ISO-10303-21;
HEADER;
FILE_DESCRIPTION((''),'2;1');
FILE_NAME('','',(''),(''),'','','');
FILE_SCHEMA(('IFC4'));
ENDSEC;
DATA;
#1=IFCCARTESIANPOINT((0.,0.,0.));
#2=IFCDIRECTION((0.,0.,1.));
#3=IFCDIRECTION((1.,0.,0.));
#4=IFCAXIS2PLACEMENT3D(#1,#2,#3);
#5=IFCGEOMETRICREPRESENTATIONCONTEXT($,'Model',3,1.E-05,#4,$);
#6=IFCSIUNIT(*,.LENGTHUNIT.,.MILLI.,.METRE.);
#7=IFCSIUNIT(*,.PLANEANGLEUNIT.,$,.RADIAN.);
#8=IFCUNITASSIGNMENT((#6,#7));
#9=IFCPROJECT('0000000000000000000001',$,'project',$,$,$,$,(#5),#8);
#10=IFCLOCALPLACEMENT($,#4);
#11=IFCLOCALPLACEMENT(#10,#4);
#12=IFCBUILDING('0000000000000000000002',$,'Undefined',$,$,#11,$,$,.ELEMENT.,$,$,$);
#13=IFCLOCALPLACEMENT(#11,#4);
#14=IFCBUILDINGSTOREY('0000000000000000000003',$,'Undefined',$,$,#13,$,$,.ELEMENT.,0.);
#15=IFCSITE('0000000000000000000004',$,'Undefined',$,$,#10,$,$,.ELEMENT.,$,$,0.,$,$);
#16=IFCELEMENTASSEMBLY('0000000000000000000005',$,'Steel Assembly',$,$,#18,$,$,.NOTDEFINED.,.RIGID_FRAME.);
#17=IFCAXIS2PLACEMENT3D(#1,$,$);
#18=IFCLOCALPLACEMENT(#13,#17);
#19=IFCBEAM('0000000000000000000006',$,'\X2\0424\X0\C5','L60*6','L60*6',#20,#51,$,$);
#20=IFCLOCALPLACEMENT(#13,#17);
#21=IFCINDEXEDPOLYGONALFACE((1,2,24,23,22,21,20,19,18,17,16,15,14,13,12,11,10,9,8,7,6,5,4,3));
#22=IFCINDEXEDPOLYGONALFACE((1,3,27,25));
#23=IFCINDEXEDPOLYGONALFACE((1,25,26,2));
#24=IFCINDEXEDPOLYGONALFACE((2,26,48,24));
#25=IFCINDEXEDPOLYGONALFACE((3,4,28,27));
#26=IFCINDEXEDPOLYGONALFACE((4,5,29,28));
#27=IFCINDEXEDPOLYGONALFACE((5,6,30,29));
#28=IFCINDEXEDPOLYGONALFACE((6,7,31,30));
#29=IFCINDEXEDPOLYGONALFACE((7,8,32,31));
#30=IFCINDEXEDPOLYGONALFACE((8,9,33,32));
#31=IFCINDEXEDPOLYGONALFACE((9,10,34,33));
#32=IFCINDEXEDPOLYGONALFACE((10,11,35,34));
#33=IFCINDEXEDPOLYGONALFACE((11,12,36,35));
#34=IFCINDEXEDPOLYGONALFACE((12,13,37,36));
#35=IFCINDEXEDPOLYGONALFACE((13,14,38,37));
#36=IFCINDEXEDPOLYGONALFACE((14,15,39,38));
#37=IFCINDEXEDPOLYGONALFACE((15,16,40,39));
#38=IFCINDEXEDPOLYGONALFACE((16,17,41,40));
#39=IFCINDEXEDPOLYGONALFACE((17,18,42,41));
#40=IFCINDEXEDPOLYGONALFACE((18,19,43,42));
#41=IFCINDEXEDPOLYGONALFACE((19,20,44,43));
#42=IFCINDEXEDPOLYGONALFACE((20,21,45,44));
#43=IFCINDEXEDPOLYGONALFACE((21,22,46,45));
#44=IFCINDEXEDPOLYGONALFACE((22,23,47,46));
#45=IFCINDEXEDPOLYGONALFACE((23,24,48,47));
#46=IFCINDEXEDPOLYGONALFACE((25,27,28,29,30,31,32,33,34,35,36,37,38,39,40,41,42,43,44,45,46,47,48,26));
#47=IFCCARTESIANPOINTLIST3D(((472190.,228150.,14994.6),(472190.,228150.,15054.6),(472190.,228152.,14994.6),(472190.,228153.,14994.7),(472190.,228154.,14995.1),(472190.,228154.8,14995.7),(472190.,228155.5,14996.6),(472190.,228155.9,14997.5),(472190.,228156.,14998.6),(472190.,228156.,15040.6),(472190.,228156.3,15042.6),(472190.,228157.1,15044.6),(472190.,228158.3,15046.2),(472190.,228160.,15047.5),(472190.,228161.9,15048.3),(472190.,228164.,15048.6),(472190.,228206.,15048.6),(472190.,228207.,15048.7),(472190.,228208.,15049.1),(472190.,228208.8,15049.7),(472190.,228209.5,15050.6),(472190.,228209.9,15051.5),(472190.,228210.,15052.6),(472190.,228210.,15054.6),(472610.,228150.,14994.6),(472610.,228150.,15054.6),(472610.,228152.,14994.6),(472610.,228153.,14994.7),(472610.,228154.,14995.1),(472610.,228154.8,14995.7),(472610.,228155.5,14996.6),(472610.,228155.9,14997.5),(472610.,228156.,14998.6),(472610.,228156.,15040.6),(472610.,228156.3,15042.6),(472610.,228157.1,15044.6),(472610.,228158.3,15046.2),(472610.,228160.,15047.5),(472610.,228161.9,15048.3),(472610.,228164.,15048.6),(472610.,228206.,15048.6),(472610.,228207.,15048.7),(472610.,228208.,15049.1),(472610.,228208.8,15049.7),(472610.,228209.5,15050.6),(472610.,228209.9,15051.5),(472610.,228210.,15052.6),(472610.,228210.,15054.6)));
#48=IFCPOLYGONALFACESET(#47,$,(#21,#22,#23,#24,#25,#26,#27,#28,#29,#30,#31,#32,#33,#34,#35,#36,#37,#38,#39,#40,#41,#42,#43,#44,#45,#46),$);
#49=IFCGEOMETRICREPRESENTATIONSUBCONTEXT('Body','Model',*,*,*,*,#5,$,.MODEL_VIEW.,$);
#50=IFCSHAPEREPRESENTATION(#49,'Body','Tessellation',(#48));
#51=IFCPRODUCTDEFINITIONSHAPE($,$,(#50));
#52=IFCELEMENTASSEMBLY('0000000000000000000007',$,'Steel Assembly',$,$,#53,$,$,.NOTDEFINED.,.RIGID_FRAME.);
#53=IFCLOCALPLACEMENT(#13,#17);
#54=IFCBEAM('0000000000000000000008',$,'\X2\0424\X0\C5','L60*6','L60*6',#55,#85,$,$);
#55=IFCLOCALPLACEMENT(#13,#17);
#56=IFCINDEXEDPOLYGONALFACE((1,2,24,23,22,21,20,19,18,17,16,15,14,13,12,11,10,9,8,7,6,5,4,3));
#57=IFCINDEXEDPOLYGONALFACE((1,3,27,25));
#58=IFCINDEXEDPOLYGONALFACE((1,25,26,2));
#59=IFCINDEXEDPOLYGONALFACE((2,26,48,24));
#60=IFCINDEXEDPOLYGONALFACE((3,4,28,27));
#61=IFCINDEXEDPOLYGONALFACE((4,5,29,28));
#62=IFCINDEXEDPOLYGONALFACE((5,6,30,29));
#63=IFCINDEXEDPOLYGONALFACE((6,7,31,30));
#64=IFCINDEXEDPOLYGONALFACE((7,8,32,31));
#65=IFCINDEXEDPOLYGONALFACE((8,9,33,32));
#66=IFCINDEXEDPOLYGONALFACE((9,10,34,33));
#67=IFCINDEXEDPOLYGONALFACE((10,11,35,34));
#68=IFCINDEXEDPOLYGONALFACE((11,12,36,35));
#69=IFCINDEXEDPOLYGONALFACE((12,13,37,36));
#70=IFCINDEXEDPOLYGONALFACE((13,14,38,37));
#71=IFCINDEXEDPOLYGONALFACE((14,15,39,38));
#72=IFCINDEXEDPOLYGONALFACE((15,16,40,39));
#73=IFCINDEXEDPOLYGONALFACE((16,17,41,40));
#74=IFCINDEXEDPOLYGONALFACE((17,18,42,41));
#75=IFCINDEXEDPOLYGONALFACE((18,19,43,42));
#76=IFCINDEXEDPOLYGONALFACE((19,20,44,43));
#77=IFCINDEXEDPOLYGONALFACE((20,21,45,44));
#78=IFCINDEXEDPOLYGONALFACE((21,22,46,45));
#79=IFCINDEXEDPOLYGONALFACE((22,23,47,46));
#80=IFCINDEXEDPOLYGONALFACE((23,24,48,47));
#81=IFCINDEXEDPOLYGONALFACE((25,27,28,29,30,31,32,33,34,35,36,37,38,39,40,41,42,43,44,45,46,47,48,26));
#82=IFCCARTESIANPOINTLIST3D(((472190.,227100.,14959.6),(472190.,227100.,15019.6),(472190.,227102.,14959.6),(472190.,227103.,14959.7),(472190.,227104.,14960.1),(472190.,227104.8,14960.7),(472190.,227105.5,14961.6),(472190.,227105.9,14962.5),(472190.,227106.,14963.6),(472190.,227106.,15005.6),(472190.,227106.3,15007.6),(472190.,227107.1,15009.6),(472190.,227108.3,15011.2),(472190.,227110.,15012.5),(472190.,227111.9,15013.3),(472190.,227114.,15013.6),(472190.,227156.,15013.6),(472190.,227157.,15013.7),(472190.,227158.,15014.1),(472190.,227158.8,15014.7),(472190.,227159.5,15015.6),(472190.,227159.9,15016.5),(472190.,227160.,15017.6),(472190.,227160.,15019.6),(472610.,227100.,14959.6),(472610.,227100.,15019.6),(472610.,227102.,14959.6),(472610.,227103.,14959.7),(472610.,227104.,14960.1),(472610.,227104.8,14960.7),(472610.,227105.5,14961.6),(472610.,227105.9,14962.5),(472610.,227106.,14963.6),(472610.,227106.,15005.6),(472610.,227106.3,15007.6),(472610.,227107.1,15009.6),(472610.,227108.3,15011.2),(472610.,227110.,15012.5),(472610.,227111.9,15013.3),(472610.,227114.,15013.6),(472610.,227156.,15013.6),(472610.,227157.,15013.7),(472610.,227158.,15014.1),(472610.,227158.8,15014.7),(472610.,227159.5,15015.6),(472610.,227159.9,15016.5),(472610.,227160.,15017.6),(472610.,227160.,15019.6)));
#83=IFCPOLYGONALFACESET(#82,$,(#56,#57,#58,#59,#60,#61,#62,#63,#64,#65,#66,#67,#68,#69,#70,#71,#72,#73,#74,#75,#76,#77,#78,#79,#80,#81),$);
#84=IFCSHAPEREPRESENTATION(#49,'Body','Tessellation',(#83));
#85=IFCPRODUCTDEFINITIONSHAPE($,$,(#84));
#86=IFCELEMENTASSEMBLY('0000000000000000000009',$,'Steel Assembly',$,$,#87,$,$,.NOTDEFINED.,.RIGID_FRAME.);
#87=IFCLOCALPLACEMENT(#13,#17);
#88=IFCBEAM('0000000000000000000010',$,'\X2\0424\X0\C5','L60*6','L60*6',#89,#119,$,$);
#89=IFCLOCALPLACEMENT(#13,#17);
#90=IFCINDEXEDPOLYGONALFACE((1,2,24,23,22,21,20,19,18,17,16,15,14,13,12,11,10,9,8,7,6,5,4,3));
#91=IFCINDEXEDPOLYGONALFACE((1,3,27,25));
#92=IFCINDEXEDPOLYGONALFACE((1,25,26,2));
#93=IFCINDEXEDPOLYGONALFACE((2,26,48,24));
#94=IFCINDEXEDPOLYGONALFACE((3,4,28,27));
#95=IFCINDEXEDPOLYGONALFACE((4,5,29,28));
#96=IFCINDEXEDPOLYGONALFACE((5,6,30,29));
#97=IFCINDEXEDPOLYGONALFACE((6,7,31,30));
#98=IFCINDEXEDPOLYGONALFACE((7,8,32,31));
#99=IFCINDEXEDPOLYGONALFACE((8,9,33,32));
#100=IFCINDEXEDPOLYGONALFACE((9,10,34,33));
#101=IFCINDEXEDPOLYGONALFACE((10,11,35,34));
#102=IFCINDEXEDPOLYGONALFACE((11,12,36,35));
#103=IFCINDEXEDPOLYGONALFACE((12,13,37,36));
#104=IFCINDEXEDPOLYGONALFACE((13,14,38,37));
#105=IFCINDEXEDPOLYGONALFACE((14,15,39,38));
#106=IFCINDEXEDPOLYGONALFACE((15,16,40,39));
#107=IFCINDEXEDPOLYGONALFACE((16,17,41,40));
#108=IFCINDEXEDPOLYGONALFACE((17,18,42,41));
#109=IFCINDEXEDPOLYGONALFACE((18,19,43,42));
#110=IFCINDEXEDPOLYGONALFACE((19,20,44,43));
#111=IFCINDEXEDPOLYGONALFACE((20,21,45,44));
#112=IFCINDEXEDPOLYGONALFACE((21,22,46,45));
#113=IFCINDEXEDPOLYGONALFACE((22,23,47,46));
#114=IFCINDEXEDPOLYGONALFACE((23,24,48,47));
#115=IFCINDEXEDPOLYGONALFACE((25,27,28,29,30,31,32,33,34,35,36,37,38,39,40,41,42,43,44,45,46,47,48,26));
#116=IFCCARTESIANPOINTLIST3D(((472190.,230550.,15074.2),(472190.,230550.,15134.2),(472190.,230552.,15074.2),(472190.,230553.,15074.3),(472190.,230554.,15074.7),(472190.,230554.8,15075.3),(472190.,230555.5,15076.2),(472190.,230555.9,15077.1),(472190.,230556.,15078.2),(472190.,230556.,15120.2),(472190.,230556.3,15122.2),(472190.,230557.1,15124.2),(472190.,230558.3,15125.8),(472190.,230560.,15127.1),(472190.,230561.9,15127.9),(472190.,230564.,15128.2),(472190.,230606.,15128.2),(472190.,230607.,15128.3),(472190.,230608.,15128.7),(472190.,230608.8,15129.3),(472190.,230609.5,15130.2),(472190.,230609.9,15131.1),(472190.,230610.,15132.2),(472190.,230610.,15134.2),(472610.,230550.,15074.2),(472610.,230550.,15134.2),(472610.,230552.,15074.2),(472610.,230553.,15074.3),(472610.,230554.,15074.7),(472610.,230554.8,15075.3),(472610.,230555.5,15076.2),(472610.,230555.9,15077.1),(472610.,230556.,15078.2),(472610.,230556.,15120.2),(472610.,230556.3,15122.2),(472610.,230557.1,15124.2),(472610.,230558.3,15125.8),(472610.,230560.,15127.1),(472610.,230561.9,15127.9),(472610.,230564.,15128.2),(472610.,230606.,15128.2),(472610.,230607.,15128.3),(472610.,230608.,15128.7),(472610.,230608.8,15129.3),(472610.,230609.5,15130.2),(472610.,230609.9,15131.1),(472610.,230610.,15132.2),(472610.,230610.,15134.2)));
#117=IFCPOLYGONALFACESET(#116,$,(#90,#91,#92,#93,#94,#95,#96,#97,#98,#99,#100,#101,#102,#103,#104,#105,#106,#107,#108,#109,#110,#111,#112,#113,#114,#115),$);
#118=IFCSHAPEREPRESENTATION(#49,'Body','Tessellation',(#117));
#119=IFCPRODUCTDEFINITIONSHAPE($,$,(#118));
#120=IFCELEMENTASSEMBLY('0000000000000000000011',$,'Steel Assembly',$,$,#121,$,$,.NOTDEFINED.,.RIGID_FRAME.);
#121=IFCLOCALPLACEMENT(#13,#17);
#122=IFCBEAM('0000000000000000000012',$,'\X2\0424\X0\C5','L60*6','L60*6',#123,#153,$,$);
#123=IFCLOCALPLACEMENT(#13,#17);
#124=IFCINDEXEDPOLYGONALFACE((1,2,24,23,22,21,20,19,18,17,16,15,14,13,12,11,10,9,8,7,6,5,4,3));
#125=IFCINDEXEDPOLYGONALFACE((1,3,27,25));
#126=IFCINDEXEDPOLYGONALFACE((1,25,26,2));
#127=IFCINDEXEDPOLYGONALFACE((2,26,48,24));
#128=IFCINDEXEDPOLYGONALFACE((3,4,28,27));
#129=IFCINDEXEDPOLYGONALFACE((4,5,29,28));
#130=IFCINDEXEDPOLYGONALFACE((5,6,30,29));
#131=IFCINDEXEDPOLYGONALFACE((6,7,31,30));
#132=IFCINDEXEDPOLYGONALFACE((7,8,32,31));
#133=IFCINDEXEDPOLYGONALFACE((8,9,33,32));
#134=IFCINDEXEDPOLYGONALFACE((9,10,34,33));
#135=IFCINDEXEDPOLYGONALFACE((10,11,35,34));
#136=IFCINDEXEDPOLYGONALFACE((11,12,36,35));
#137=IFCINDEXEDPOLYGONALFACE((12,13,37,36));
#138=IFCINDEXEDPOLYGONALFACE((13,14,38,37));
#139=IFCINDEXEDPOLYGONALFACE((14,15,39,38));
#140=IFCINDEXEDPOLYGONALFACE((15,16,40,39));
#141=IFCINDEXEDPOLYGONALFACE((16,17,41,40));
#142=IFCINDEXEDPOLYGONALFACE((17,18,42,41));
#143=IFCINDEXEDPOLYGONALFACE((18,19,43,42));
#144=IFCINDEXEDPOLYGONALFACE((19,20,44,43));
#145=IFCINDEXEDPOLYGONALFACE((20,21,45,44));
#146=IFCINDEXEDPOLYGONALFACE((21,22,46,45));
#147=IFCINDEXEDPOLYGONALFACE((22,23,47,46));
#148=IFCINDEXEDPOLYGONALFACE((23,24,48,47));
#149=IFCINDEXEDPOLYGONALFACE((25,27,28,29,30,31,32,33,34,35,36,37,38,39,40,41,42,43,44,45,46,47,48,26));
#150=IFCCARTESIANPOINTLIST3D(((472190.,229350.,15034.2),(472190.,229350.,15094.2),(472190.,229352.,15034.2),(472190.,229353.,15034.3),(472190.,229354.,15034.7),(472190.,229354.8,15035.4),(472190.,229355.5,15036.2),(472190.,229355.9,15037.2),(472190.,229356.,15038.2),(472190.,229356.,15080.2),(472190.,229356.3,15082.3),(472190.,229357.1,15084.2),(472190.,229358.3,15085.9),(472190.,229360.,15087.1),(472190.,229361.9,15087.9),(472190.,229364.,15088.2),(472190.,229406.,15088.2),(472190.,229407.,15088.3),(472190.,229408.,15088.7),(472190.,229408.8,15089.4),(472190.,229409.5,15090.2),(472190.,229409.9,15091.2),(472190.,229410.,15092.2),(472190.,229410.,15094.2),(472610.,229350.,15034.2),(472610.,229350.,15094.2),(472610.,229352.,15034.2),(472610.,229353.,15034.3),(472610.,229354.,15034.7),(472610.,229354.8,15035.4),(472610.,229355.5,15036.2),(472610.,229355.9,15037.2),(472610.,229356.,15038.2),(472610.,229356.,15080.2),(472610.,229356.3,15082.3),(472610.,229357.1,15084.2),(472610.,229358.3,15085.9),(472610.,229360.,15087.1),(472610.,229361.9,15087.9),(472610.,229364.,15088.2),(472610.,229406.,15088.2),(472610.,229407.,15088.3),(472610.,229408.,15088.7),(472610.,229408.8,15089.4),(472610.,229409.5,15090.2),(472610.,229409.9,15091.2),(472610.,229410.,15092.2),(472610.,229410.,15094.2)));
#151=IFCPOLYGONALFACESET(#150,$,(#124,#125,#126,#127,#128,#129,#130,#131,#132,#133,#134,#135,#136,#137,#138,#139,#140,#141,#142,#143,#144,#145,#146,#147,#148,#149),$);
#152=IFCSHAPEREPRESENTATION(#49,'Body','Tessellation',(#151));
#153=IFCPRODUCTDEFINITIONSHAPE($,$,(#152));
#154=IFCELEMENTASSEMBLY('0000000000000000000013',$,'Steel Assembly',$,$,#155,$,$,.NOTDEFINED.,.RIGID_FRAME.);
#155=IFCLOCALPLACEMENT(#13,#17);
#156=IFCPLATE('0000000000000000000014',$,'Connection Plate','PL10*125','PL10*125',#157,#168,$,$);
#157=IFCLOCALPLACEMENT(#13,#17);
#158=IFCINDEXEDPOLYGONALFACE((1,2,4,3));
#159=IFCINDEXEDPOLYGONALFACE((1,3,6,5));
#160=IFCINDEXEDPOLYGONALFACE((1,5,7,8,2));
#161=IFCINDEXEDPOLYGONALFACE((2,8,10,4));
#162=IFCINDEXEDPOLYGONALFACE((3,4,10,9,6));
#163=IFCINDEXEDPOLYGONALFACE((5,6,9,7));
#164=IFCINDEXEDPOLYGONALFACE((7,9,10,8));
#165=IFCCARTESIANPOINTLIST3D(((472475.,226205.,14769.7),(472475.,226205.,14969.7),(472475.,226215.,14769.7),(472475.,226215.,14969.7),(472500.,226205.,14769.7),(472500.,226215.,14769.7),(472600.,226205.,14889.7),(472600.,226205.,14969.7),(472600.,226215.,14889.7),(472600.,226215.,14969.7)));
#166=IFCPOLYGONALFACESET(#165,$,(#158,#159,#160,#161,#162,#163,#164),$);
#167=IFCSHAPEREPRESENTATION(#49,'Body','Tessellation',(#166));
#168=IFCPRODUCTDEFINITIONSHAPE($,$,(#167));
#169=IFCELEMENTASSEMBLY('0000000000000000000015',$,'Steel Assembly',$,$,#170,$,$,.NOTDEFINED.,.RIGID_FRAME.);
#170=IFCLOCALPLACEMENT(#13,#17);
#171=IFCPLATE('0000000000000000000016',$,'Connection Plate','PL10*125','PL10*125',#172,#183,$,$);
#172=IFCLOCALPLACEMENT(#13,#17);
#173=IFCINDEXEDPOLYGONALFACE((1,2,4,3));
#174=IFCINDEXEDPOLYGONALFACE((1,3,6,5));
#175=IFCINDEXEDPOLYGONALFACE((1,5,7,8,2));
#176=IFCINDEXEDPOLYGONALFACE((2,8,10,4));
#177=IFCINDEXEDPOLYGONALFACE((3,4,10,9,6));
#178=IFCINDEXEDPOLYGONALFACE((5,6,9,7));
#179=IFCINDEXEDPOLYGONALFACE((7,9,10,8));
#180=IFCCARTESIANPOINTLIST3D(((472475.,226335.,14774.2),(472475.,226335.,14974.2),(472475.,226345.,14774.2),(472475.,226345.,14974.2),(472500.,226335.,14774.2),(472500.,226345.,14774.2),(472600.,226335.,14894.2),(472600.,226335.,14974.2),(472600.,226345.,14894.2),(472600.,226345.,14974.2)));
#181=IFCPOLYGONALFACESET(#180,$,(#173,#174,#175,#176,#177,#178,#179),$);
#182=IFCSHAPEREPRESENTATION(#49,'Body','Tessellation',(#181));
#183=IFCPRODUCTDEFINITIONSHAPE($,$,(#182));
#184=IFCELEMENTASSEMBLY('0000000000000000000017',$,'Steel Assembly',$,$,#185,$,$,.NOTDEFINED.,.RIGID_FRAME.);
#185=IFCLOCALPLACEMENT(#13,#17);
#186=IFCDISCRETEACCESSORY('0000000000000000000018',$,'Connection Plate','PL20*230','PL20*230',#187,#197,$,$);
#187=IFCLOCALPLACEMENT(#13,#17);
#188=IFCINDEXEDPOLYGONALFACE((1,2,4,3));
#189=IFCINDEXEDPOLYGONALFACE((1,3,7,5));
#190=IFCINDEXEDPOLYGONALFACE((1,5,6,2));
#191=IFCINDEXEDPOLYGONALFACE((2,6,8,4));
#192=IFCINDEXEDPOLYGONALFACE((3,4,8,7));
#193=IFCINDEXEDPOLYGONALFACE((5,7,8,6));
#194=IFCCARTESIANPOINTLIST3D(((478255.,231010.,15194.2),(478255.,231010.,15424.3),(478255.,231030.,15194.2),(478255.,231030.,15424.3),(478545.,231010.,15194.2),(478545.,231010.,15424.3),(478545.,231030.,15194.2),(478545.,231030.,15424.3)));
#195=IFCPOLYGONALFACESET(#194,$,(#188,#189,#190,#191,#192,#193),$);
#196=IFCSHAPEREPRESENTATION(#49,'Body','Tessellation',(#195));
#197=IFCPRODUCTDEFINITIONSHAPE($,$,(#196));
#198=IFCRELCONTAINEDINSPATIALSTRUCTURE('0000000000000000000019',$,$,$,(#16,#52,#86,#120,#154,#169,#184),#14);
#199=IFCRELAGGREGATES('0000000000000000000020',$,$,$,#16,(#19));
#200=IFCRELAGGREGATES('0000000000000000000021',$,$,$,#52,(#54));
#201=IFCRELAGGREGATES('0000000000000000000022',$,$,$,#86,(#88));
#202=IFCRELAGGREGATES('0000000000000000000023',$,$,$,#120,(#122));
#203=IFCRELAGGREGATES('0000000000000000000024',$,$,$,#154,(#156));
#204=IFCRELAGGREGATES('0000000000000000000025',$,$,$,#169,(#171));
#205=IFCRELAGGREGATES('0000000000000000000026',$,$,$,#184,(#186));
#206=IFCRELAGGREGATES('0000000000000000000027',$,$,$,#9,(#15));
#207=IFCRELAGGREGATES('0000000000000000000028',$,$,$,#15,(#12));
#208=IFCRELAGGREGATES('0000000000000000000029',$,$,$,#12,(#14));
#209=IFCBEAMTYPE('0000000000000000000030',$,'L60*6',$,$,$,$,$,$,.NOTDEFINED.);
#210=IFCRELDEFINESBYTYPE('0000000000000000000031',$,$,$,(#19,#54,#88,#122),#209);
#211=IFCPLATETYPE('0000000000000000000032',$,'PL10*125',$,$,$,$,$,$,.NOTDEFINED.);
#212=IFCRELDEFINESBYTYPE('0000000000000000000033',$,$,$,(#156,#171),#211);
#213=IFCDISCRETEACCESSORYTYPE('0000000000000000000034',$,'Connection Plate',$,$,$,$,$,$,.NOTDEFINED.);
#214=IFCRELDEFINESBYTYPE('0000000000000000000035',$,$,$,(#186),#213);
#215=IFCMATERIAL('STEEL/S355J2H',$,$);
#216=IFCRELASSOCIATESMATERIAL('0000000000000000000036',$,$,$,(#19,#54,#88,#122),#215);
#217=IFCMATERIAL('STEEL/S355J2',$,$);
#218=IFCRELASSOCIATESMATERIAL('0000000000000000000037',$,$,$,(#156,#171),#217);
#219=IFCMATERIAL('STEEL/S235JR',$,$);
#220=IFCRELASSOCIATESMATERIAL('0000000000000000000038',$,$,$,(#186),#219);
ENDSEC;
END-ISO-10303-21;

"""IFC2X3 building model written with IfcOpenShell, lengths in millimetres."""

from ifc_helpers import new_model, si_unit, frame, origin_with_axes, origin_2d_with_axis, place, context, subcontext, project, spatial, polyline, l_section, outline, extrude, material, type_object, element, aggregate, save


model = new_model("IFC2X3")

# Units and contexts
model_context = context("Model", 3, precision=1e-05, world=origin_with_axes())
body_context = subcontext(model_context, "Body", "Model", "MODEL_VIEW")
ifc_project = project(units=[si_unit("LENGTHUNIT", "METRE", prefix="MILLI"), si_unit("PLANEANGLEUNIT", "RADIAN")], contexts=[model_context])

# Site, building, storey
site_placement = place(None, origin_with_axes())
site = spatial("IfcSite", under=ifc_project, at=site_placement, Name="Undefined", CompositionType="ELEMENT", RefElevation=0.0)
building_placement = place(site_placement, origin_with_axes())
building = spatial("IfcBuilding", under=site, at=building_placement, Name="Undefined", CompositionType="ELEMENT")
storey_placement = place(building_placement, origin_with_axes())
storey = spatial("IfcBuildingStorey", under=building, at=storey_placement, Name="Undefined", CompositionType="ELEMENT", Elevation=0.0)

# Element assemblies, beams
assembly_1_placement = place(storey_placement, origin_with_axes())
assembly_1 = element("IfcElementAssembly", 1, at=assembly_1_placement, inside=storey, Name="Steel Assembly", AssemblyPlace="NOTDEFINED", PredefinedType="RIGID_FRAME")
ifc_material_1 = material(Name="STEEL/S355J2H")
beam_type = type_object("IfcBeamType", Name="L60*6", PredefinedType="NOTDEFINED")
beam_1_placement = place(assembly_1_placement, frame((472610.0, 228180.0, 15024.6), z_axis=(0.0, 1.0, 0.0), x_axis=(-1.0, 0.0, 0.0)))
beam_1 = element("IfcBeam", 2, at=beam_1_placement, type_object=beam_type, material=ifc_material_1, Name="ФC5", Description="L60*6", ObjectType="L60*6", context=body_context, shape_type="SweptSolid", body=[
    extrude(l_section(Depth=60.0, Width=60.0, Thickness=6.0, FilletRadius=8.0, EdgeRadius=4.0, at=origin_2d_with_axis()), frame((420.0, 0.0, 0.0), z_axis=(-1.0, 0.0, 0.0), x_axis=(0.0, -1.0, 0.0)), (0.0, 0.0, 1.0), 420.0),
])
aggregate(assembly_1, [beam_1])
assembly_2_placement = place(storey_placement, origin_with_axes())
assembly_2 = element("IfcElementAssembly", 3, at=assembly_2_placement, inside=storey, Name="Steel Assembly", AssemblyPlace="NOTDEFINED", PredefinedType="RIGID_FRAME")
beam_2_placement = place(assembly_2_placement, frame((472610.0, 227130.0, 14989.6), z_axis=(0.0, 1.0, 0.0), x_axis=(-1.0, 0.0, 0.0)))
beam_2 = element("IfcBeam", 4, at=beam_2_placement, type_object=beam_type, material=ifc_material_1, Name="ФC5", Description="L60*6", ObjectType="L60*6", context=body_context, shape_type="SweptSolid", body=[
    extrude(l_section(Depth=60.0, Width=60.0, Thickness=6.0, FilletRadius=8.0, EdgeRadius=4.0, at=origin_2d_with_axis()), frame((420.0, 0.0, 0.0), z_axis=(-1.0, 0.0, 0.0), x_axis=(0.0, -1.0, 0.0)), (0.0, 0.0, 1.0), 420.0),
])
aggregate(assembly_2, [beam_2])
assembly_3_placement = place(storey_placement, origin_with_axes())
assembly_3 = element("IfcElementAssembly", 5, at=assembly_3_placement, inside=storey, Name="Steel Assembly", AssemblyPlace="NOTDEFINED", PredefinedType="RIGID_FRAME")
beam_3_placement = place(assembly_3_placement, frame((472610.0, 230580.0, 15104.2), z_axis=(0.0, 1.0, 0.0), x_axis=(-1.0, 0.0, 0.0)))
beam_3 = element("IfcBeam", 6, at=beam_3_placement, type_object=beam_type, material=ifc_material_1, Name="ФC5", Description="L60*6", ObjectType="L60*6", context=body_context, shape_type="SweptSolid", body=[
    extrude(l_section(Depth=60.0, Width=60.0, Thickness=6.0, FilletRadius=8.0, EdgeRadius=4.0, at=origin_2d_with_axis()), frame((420.0, 0.0, 0.0), z_axis=(-1.0, 0.0, 0.0), x_axis=(0.0, -1.0, 0.0)), (0.0, 0.0, 1.0), 420.0),
])
aggregate(assembly_3, [beam_3])
assembly_4_placement = place(storey_placement, origin_with_axes())
assembly_4 = element("IfcElementAssembly", 7, at=assembly_4_placement, inside=storey, Name="Steel Assembly", AssemblyPlace="NOTDEFINED", PredefinedType="RIGID_FRAME")
beam_4_placement = place(assembly_4_placement, frame((472610.0, 229380.0, 15064.2), z_axis=(0.0, 1.0, 0.0), x_axis=(-1.0, 0.0, 0.0)))
beam_4 = element("IfcBeam", 8, at=beam_4_placement, type_object=beam_type, material=ifc_material_1, Name="ФC5", Description="L60*6", ObjectType="L60*6", context=body_context, shape_type="SweptSolid", body=[
    extrude(l_section(Depth=60.0, Width=60.0, Thickness=6.0, FilletRadius=8.0, EdgeRadius=4.0, at=origin_2d_with_axis()), frame((420.0, 0.0, 0.0), z_axis=(-1.0, 0.0, 0.0), x_axis=(0.0, -1.0, 0.0)), (0.0, 0.0, 1.0), 420.0),
])
aggregate(assembly_4, [beam_4])

# Element assemblies, plates
assembly_5_placement = place(storey_placement, origin_with_axes())
assembly_5 = element("IfcElementAssembly", 9, at=assembly_5_placement, inside=storey, Name="Steel Assembly", AssemblyPlace="NOTDEFINED", PredefinedType="RIGID_FRAME")
ifc_material_2 = material(Name="STEEL/S355J2")
plate_type = type_object("IfcPlateType", Name="PL10*125", PredefinedType="NOTDEFINED")
plate_1_placement = place(assembly_5_placement, frame((472600.0, 226210.0, 14969.7), z_axis=(0.0, -1.0, 0.0), x_axis=(-1.0, 0.0, 0.0)))
plate_1 = element("IfcPlate", 10, at=plate_1_placement, type_object=plate_type, material=ifc_material_2, Name="Connection Plate", Description="PL10*125", ObjectType="PL10*125", context=body_context, shape_type="SweptSolid", body=[
    extrude(outline(polyline([(0.0, 0.0), (125.0, 0.0), (125.0, 200.0), (100.0, 200.0), (0.0, 80.0), (0.0, 0.0)])), frame((0.0, 0.0, -5.0), z_axis=(0.0, 0.0, 1.0), x_axis=(1.0, 0.0, 0.0)), (0.0, 0.0, 1.0), 10.0),
])
aggregate(assembly_5, [plate_1])
assembly_6_placement = place(storey_placement, origin_with_axes())
assembly_6 = element("IfcElementAssembly", 11, at=assembly_6_placement, inside=storey, Name="Steel Assembly", AssemblyPlace="NOTDEFINED", PredefinedType="RIGID_FRAME")
plate_2_placement = place(assembly_6_placement, frame((472600.0, 226340.0, 14974.2), z_axis=(0.0, -1.0, 0.0), x_axis=(-1.0, 0.0, 0.0)))
plate_2 = element("IfcPlate", 12, at=plate_2_placement, type_object=plate_type, material=ifc_material_2, Name="Connection Plate", Description="PL10*125", ObjectType="PL10*125", context=body_context, shape_type="SweptSolid", body=[
    extrude(outline(polyline([(0.0, 0.0), (125.0, 0.0), (125.0, 200.0), (100.0, 200.0), (0.0, 80.0), (0.0, 0.0)])), frame((0.0, 0.0, -5.0), z_axis=(0.0, 0.0, 1.0), x_axis=(1.0, 0.0, 0.0)), (0.0, 0.0, 1.0), 10.0),
])
aggregate(assembly_6, [plate_2])

# Element assembly, discrete accessory
assembly_7_placement = place(storey_placement, origin_with_axes())
assembly_7 = element("IfcElementAssembly", 13, at=assembly_7_placement, inside=storey, Name="Steel Assembly", AssemblyPlace="NOTDEFINED", PredefinedType="RIGID_FRAME")
ifc_material_3 = material(Name="STEEL/S235JR")
discrete_accessory_type_1 = type_object("IfcDiscreteAccessoryType", Name="Connection Plate")
discrete_accessory_1_placement = place(assembly_7_placement, frame((478545.0, 231020.0, 15424.3), z_axis=(0.0, -1.0, 0.0), x_axis=(-1.0, 0.0, 0.0)))
discrete_accessory_1 = element("IfcDiscreteAccessory", 14, at=discrete_accessory_1_placement, type_object=discrete_accessory_type_1, material=ifc_material_3, Name="Connection Plate", Description="PL20*230", ObjectType="PL20*230", context=body_context, shape_type="SweptSolid", body=[
    extrude(outline(polyline([(0.0, 0.0), (290.0, 0.0), (290.0, 230.1), (0.0, 230.1), (0.0, 0.0)])), frame((0.0, 0.0, -10.0), z_axis=(0.0, 0.0, 1.0), x_axis=(1.0, 0.0, 0.0)), (0.0, 0.0, 1.0), 20.0),
])

aggregate(assembly_7, [discrete_accessory_1])

save(model, "model.ifc")
